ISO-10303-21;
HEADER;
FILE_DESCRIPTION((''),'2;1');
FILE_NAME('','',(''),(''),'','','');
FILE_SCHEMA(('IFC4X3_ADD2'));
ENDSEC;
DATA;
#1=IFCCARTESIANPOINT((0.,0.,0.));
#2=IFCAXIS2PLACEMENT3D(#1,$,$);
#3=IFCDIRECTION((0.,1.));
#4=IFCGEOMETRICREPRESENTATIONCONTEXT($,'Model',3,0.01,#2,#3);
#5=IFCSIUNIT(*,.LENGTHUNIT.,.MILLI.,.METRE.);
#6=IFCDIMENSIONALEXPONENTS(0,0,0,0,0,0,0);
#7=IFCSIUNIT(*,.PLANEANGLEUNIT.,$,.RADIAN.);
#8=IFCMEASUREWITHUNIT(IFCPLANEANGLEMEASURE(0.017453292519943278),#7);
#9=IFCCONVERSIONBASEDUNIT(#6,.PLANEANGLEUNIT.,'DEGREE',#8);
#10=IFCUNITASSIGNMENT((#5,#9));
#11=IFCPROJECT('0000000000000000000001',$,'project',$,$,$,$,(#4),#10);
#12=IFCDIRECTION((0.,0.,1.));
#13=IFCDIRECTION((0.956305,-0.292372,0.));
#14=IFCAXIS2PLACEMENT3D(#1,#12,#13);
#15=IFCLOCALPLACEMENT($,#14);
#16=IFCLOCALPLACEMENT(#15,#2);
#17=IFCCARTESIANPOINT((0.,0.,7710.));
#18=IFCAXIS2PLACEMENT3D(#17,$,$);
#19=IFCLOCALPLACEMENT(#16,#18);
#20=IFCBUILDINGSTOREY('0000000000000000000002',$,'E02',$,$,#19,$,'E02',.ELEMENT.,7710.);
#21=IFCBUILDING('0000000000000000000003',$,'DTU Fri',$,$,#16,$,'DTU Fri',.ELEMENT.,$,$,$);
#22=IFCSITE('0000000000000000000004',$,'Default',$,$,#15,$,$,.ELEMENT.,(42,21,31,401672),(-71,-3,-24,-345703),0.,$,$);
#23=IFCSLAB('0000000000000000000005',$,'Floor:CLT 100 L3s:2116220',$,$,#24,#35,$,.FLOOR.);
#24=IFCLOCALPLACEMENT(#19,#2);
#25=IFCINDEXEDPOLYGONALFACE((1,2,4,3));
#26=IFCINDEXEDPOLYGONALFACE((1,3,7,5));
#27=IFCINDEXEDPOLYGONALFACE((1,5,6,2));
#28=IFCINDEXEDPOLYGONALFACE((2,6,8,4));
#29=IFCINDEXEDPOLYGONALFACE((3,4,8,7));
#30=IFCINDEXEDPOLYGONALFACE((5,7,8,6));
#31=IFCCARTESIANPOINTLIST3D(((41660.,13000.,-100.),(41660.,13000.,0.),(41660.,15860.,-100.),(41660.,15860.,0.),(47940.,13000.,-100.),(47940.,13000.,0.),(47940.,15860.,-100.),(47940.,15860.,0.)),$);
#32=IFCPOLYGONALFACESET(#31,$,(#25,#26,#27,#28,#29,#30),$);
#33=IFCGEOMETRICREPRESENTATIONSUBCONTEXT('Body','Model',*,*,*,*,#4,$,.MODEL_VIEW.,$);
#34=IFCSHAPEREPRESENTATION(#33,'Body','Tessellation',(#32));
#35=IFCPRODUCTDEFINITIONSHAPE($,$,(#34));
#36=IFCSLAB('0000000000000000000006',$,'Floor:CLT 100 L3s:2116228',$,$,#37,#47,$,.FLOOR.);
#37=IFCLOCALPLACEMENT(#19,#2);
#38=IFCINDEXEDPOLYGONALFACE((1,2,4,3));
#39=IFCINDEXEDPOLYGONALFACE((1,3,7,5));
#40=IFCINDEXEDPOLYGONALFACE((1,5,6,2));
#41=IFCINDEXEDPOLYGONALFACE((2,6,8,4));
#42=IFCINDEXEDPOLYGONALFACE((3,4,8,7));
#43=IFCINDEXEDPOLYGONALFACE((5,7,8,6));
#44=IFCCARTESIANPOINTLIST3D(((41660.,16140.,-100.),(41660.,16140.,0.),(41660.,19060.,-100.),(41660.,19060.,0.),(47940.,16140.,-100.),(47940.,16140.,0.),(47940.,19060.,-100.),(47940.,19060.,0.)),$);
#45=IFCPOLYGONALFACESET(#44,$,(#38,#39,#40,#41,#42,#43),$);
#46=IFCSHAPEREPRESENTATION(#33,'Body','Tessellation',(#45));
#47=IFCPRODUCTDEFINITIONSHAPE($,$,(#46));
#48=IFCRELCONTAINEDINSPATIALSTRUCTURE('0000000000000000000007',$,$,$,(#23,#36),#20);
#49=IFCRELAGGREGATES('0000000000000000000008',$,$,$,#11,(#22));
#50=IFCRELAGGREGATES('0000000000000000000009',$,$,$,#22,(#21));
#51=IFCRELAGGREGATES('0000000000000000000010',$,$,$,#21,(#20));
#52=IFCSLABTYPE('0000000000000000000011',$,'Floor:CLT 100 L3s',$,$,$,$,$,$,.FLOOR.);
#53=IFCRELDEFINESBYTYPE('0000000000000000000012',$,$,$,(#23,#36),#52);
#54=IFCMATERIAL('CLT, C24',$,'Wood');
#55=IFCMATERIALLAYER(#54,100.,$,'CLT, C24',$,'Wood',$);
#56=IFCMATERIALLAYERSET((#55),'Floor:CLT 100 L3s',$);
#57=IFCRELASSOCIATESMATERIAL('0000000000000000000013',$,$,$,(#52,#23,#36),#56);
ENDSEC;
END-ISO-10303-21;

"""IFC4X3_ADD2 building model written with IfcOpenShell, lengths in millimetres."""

from ifc_helpers import new_model, entity, si_unit, converted_unit, direction, frame, frame_2d, origin, place, context, subcontext, project, spatial, rectangle, extrude, material, layer, layer_set, layer_usage, type_object, element, save


model = new_model("IFC4X3_ADD2")

# Units and contexts
model_context = context("Model", 3, precision=0.01, world=origin(), true_north=direction((0.0, 1.0)))
body_context = subcontext(model_context, "Body", "Model", "MODEL_VIEW")
ifc_project = project(units=[si_unit("LENGTHUNIT", "METRE", prefix="MILLI"), converted_unit("PLANEANGLEUNIT", "DEGREE", entity("IfcPlaneAngleMeasure", 0.017453292519943278), si_unit("PLANEANGLEUNIT", "RADIAN"), dimensions=[0, 0, 0, 0, 0, 0, 0])], contexts=[model_context])

# Site, building, storey
site_placement = place(None, frame((0.0, 0.0, 0.0), z_axis=(0.0, 0.0, 1.0), x_axis=(0.956305, -0.292372, 0.0)))
site = spatial("IfcSite", under=ifc_project, at=site_placement, Name="Default", CompositionType="ELEMENT", RefLatitude=(42, 21, 31, 401672), RefLongitude=(-71, -3, -24, -345703), RefElevation=0.0)
building_placement = place(site_placement, origin())
building = spatial("IfcBuilding", under=site, at=building_placement, Name="DTU Fri", LongName="DTU Fri", CompositionType="ELEMENT")
storey_placement = place(building_placement, frame((0.0, 0.0, 7710.0)))
storey = spatial("IfcBuildingStorey", under=building, at=storey_placement, Name="E02", LongName="E02", CompositionType="ELEMENT", Elevation=7710.0)

# Slabs
ifc_material_1 = material(Name="CLT, C24", Category="Wood")
ifc_layer_1 = layer(ifc_material_1, 100.0, Name="CLT, C24", Category="Wood")
ifc_layer_set_1 = layer_set([ifc_layer_1], Name="Floor:CLT 100 L3s")
slab_type_1 = type_object("IfcSlabType", Name="Floor:CLT 100 L3s", PredefinedType="FLOOR", material=ifc_layer_set_1)
ifc_layer_usage_1 = layer_usage(ifc_layer_set_1, "AXIS3", "POSITIVE", 0.0)
slab_1_placement = place(storey_placement, origin())
element("IfcSlab", 1, at=slab_1_placement, inside=storey, type_object=slab_type_1, material=ifc_layer_usage_1, Name="Floor:CLT 100 L3s:2116220", PredefinedType="FLOOR", context=body_context, shape_type="SweptSolid", body=[
    extrude(rectangle(XDim=2860.0, YDim=6280.0, at=frame_2d((0.0, 0.0), x_axis=(1.0, 0.0))), frame((44800.0, 14430.0, 0.0), z_axis=(0.0, 0.0, -1.0), x_axis=(0.0, 1.0, 0.0)), (0.0, 0.0, 1.0), 100.0),
])
ifc_layer_usage_2 = layer_usage(ifc_layer_set_1, "AXIS3", "POSITIVE", 0.0)
slab_2_placement = place(storey_placement, origin())
element("IfcSlab", 2, at=slab_2_placement, inside=storey, type_object=slab_type_1, material=ifc_layer_usage_2, Name="Floor:CLT 100 L3s:2116228", PredefinedType="FLOOR", context=body_context, shape_type="SweptSolid", body=[
    extrude(rectangle(XDim=2920.0, YDim=6280.0, at=frame_2d((0.0, 0.0), x_axis=(1.0, 0.0))), frame((44800.0, 17600.0, 0.0), z_axis=(0.0, 0.0, -1.0), x_axis=(0.0, 1.0, 0.0)), (0.0, 0.0, 1.0), 100.0),
])

save(model, "model.ifc")
